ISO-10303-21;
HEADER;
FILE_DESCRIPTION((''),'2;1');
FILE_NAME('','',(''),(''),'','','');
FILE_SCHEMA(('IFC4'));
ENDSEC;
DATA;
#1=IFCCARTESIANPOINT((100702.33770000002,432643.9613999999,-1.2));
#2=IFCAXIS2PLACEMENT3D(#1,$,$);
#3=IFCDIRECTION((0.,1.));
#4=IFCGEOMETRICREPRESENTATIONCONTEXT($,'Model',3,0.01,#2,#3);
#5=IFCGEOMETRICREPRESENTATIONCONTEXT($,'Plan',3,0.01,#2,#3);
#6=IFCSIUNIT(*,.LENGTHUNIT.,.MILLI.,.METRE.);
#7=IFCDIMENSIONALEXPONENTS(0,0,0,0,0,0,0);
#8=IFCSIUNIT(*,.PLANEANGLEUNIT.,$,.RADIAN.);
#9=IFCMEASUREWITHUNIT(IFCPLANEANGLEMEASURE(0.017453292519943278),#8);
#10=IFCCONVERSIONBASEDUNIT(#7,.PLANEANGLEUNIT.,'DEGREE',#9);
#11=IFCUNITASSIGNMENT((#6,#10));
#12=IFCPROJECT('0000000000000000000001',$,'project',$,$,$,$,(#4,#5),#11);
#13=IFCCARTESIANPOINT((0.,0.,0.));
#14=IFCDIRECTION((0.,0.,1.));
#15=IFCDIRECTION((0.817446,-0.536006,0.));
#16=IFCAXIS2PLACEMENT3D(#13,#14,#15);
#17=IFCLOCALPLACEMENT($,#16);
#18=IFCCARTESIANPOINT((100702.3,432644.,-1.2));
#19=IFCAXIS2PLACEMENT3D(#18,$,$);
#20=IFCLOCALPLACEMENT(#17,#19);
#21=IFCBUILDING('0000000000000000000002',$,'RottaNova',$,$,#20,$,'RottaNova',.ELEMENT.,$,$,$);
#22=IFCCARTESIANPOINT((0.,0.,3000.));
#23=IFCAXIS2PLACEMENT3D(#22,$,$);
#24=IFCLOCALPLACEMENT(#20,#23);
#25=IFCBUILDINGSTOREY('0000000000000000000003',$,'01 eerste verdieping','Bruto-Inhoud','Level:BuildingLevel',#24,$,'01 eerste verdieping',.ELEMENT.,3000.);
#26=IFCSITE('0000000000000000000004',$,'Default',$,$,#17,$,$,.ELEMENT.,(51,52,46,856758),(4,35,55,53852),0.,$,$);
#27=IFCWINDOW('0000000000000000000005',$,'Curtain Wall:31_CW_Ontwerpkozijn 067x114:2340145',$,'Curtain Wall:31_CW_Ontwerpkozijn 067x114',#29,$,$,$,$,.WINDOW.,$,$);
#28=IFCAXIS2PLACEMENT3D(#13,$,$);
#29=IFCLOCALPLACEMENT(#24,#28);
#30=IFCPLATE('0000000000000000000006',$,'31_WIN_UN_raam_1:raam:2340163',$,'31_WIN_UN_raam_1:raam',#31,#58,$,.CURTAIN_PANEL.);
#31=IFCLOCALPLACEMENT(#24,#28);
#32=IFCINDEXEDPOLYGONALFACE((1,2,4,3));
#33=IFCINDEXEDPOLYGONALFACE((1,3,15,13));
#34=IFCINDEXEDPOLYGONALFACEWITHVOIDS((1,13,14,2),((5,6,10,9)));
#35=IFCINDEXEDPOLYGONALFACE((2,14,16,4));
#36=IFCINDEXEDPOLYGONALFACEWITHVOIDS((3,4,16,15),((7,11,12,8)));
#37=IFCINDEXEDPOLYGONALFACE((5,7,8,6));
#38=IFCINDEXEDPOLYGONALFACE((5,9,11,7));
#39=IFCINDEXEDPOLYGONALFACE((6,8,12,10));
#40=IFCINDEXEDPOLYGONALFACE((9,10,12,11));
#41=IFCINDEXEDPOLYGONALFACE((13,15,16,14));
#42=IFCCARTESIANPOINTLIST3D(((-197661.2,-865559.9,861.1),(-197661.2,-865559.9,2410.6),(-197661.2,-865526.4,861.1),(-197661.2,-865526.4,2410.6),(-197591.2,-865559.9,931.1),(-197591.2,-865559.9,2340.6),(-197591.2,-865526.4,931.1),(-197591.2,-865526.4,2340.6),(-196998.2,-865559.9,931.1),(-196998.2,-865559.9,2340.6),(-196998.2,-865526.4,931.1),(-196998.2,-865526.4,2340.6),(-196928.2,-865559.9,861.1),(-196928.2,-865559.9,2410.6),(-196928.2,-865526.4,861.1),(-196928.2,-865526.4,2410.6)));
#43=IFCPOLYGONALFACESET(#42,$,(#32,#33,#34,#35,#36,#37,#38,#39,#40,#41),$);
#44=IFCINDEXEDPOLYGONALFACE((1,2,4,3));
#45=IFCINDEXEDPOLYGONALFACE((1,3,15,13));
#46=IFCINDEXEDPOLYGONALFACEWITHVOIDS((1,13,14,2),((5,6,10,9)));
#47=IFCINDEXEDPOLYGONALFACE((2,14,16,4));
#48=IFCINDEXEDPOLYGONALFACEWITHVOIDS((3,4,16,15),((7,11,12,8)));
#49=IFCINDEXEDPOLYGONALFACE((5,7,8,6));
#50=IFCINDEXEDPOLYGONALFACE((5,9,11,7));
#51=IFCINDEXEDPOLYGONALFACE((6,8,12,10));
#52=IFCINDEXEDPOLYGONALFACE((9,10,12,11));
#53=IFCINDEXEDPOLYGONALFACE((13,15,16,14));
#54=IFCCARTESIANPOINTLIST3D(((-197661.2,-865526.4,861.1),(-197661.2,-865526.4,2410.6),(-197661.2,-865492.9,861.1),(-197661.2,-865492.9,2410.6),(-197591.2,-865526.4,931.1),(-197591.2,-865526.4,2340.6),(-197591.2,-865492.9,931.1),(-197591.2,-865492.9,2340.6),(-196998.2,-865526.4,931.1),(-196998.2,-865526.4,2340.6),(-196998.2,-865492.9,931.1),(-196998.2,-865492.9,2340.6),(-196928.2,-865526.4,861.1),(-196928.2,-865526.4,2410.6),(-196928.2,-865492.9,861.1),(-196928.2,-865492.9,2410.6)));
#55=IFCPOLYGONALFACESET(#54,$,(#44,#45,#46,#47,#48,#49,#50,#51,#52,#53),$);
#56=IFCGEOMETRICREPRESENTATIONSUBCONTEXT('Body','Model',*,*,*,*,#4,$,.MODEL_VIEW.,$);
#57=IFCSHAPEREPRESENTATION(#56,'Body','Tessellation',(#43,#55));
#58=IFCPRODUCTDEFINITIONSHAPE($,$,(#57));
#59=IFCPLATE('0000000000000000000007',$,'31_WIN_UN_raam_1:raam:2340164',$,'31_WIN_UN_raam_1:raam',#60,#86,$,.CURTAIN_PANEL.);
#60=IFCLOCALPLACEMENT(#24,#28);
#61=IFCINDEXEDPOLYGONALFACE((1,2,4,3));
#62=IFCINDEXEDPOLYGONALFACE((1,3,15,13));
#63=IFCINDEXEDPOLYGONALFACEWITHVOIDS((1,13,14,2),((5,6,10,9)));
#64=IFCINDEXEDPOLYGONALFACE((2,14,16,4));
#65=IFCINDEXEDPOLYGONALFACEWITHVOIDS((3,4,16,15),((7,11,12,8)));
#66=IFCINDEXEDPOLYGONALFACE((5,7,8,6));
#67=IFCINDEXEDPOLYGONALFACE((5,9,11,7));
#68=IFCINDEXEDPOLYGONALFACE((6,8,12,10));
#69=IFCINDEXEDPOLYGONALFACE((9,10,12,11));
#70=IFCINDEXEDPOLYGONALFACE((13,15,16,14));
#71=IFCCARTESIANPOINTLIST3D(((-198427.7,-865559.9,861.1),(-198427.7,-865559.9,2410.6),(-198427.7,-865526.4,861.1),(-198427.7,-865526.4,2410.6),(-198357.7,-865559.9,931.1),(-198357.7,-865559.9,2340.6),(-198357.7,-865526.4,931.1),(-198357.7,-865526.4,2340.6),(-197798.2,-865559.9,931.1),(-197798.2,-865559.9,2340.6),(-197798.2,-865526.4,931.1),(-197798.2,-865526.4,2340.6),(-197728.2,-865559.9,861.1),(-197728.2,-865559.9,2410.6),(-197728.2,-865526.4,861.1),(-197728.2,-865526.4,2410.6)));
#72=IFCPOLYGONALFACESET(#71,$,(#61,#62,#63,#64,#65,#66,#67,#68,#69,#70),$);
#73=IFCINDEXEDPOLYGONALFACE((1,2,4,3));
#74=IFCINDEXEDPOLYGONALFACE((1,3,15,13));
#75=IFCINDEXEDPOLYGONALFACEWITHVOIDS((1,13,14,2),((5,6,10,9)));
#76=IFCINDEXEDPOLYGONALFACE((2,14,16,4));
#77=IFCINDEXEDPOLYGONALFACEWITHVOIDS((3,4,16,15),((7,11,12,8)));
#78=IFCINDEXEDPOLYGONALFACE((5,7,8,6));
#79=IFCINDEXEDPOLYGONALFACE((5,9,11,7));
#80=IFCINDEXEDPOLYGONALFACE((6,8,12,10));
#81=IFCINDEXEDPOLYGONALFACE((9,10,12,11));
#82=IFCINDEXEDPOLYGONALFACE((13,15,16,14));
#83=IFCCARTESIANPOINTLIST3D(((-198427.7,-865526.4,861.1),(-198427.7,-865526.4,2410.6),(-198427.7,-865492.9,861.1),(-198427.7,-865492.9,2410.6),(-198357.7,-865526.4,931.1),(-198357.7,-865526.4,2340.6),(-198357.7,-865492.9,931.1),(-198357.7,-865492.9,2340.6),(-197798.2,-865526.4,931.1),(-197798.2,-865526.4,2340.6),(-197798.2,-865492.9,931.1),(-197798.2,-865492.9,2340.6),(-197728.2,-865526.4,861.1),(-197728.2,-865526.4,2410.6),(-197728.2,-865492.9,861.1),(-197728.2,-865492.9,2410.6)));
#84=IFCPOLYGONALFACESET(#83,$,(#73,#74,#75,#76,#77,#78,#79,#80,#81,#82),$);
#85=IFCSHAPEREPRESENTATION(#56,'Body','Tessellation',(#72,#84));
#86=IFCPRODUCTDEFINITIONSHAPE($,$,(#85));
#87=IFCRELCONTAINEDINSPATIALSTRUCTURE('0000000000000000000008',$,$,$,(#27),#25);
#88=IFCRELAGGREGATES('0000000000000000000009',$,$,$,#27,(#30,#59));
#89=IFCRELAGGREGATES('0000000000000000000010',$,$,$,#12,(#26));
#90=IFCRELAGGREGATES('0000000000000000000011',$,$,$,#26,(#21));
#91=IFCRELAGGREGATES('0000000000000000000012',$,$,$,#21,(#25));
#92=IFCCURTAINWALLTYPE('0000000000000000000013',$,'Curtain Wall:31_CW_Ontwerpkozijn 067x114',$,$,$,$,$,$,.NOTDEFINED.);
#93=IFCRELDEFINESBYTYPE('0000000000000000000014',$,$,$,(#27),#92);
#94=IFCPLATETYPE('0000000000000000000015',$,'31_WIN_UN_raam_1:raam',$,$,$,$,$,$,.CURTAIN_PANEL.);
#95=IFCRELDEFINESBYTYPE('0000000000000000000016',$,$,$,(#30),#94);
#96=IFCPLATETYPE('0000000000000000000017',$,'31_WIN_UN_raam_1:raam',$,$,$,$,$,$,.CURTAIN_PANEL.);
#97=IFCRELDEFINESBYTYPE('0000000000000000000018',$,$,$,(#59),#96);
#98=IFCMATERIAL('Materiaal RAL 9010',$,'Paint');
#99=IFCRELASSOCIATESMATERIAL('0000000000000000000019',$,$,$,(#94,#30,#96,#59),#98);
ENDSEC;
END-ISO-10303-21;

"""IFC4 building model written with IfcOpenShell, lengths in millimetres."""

from ifc_helpers import new_model, entity, si_unit, converted_unit, direction, frame, place, context, subcontext, project, spatial, indexed_curve, outline, extrude, source, transform, mapped, material, type_object, type_shapes, element, aggregate, save


model = new_model("IFC4")

# Units and contexts
model_context = context("Model", 3, precision=0.01, world=frame((100702.33770000002, 432643.9613999999, -1.2)), true_north=direction((0.0, 1.0)))
plan_context = context("Plan", 3, precision=0.01, world=frame((100702.33770000002, 432643.9613999999, -1.2)), true_north=direction((0.0, 1.0)))
body_context = subcontext(model_context, "Body", "Model", "MODEL_VIEW")
ifc_project = project(units=[si_unit("LENGTHUNIT", "METRE", prefix="MILLI"), converted_unit("PLANEANGLEUNIT", "DEGREE", entity("IfcPlaneAngleMeasure", 0.017453292519943278), si_unit("PLANEANGLEUNIT", "RADIAN"), dimensions=[0, 0, 0, 0, 0, 0, 0])], contexts=[model_context, plan_context])

# Site, building, storey
site_placement = place(None, frame((0.0, 0.0, 0.0), z_axis=(0.0, 0.0, 1.0), x_axis=(0.817446, -0.536006, 0.0)))
site = spatial("IfcSite", under=ifc_project, at=site_placement, Name="Default", CompositionType="ELEMENT", RefLatitude=(51, 52, 46, 856758), RefLongitude=(4, 35, 55, 53852), RefElevation=0.0)
building_placement = place(site_placement, frame((100702.3, 432644.0, -1.2)))
building = spatial("IfcBuilding", under=site, at=building_placement, Name="RottaNova", LongName="RottaNova", CompositionType="ELEMENT")
storey_placement = place(building_placement, frame((0.0, 0.0, 3000.0)))
storey = spatial("IfcBuildingStorey", under=building, at=storey_placement, Name="01 eerste verdieping", Description="Bruto-Inhoud", ObjectType="Level:BuildingLevel", LongName="01 eerste verdieping", CompositionType="ELEMENT", Elevation=3000.0)

# Shared definitions
curtain_wall_type = type_object("IfcCurtainWallType", Name="Curtain Wall:31_CW_Ontwerpkozijn 067x114", PredefinedType="NOTDEFINED")

# Window, plates
window_1_placement = place(storey_placement, frame((0.0, 0.0, -3000.0)))
window_1 = element("IfcWindow", 1, at=window_1_placement, inside=storey, type_object=curtain_wall_type, Name="Curtain Wall:31_CW_Ontwerpkozijn 067x114:2340145", ObjectType="Curtain Wall:31_CW_Ontwerpkozijn 067x114", PredefinedType="WINDOW")
ifc_material_1 = material(Name="Materiaal RAL 9010", Category="Paint")
plate_type_1 = type_object("IfcPlateType", Name="31_WIN_UN_raam_1:raam", PredefinedType="CURTAIN_PANEL", material=ifc_material_1)
shared_shape_1 = source(frame((100702.3, 432644.0, -1.2)), body_context, "Body", "SweptSolid", [
    extrude(outline(indexed_curve([(-366.5, -774.8), (366.5, -774.8), (366.5, 774.8), (-366.5, 774.8), (-366.5, -774.8)], self_intersect=False), holes=[indexed_curve([(-296.5, 704.8), (296.5, 704.8), (296.5, -704.8), (-296.5, -704.8), (-296.5, 704.8)], self_intersect=False)]), frame((0.0, 58.5, 774.8), z_axis=(0.0, 1.0, 0.0), x_axis=(1.0, 0.0, 0.0)), (0.0, 0.0, 1.0), 33.5),
    extrude(outline(indexed_curve([(-366.5, -774.8), (366.5, -774.8), (366.5, 774.8), (-366.5, 774.8), (-366.5, -774.8)], self_intersect=False), holes=[indexed_curve([(-296.5, 704.7), (296.5, 704.7), (296.5, -704.8), (-296.5, -704.8), (-296.5, 704.7)], self_intersect=False)]), frame((0.0, 25.0, 774.8), z_axis=(0.0, 1.0, 0.0), x_axis=(1.0, 0.0, 0.0)), (0.0, 0.0, 1.0), 33.5),
])
type_shapes(plate_type_1, [shared_shape_1])
plate_1_placement = place(window_1_placement, frame((4110.0, -180.0, 3863.5), z_axis=(0.0, 0.0, 1.0), x_axis=(-1.0, 0.0, 0.0)))
plate_1 = element("IfcPlate", 2, at=plate_1_placement, type_object=plate_type_1, material=ifc_material_1, Name="31_WIN_UN_raam_1:raam:2340163", ObjectType="31_WIN_UN_raam_1:raam", PredefinedType="CURTAIN_PANEL", context=body_context, shape_type="MappedRepresentation", body=[
    mapped(shared_shape_1, transform((100702.3, 432644.0, -1.2), scale=1.0)),
])
plate_type_2 = type_object("IfcPlateType", Name="31_WIN_UN_raam_1:raam", PredefinedType="CURTAIN_PANEL", material=ifc_material_1)
shared_shape_2 = source(frame((100702.3, 432644.0, -1.2)), body_context, "Body", "SweptSolid", [
    extrude(outline(indexed_curve([(-349.7, -774.8), (349.7, -774.8), (349.7, 774.8), (-349.7, 774.8), (-349.7, -774.8)], self_intersect=False), holes=[indexed_curve([(-279.7, 704.8), (279.7, 704.8), (279.7, -704.8), (-279.7, -704.8), (-279.7, 704.8)], self_intersect=False)]), frame((0.0, 58.5, 774.8), z_axis=(0.0, 1.0, 0.0), x_axis=(1.0, 0.0, 0.0)), (0.0, 0.0, 1.0), 33.5),
    extrude(outline(indexed_curve([(-349.7, -774.8), (349.7, -774.8), (349.7, 774.8), (-349.7, 774.8), (-349.7, -774.8)], self_intersect=False), holes=[indexed_curve([(-279.7, 704.7), (279.7, 704.7), (279.7, -704.8), (-279.7, -704.8), (-279.7, 704.7)], self_intersect=False)]), frame((0.0, 25.0, 774.8), z_axis=(0.0, 1.0, 0.0), x_axis=(1.0, 0.0, 0.0)), (0.0, 0.0, 1.0), 33.5),
])
type_shapes(plate_type_2, [shared_shape_2])
plate_2_placement = place(window_1_placement, frame((3326.7, -180.0, 3863.5), z_axis=(0.0, 0.0, 1.0), x_axis=(-1.0, 0.0, 0.0)))
plate_2 = element("IfcPlate", 3, at=plate_2_placement, type_object=plate_type_2, material=ifc_material_1, Name="31_WIN_UN_raam_1:raam:2340164", ObjectType="31_WIN_UN_raam_1:raam", PredefinedType="CURTAIN_PANEL", context=body_context, shape_type="MappedRepresentation", body=[
    mapped(shared_shape_2, transform((100702.3, 432644.0, -1.2), scale=1.0)),
])
aggregate(window_1, [plate_1, plate_2])

save(model, "model.ifc")
